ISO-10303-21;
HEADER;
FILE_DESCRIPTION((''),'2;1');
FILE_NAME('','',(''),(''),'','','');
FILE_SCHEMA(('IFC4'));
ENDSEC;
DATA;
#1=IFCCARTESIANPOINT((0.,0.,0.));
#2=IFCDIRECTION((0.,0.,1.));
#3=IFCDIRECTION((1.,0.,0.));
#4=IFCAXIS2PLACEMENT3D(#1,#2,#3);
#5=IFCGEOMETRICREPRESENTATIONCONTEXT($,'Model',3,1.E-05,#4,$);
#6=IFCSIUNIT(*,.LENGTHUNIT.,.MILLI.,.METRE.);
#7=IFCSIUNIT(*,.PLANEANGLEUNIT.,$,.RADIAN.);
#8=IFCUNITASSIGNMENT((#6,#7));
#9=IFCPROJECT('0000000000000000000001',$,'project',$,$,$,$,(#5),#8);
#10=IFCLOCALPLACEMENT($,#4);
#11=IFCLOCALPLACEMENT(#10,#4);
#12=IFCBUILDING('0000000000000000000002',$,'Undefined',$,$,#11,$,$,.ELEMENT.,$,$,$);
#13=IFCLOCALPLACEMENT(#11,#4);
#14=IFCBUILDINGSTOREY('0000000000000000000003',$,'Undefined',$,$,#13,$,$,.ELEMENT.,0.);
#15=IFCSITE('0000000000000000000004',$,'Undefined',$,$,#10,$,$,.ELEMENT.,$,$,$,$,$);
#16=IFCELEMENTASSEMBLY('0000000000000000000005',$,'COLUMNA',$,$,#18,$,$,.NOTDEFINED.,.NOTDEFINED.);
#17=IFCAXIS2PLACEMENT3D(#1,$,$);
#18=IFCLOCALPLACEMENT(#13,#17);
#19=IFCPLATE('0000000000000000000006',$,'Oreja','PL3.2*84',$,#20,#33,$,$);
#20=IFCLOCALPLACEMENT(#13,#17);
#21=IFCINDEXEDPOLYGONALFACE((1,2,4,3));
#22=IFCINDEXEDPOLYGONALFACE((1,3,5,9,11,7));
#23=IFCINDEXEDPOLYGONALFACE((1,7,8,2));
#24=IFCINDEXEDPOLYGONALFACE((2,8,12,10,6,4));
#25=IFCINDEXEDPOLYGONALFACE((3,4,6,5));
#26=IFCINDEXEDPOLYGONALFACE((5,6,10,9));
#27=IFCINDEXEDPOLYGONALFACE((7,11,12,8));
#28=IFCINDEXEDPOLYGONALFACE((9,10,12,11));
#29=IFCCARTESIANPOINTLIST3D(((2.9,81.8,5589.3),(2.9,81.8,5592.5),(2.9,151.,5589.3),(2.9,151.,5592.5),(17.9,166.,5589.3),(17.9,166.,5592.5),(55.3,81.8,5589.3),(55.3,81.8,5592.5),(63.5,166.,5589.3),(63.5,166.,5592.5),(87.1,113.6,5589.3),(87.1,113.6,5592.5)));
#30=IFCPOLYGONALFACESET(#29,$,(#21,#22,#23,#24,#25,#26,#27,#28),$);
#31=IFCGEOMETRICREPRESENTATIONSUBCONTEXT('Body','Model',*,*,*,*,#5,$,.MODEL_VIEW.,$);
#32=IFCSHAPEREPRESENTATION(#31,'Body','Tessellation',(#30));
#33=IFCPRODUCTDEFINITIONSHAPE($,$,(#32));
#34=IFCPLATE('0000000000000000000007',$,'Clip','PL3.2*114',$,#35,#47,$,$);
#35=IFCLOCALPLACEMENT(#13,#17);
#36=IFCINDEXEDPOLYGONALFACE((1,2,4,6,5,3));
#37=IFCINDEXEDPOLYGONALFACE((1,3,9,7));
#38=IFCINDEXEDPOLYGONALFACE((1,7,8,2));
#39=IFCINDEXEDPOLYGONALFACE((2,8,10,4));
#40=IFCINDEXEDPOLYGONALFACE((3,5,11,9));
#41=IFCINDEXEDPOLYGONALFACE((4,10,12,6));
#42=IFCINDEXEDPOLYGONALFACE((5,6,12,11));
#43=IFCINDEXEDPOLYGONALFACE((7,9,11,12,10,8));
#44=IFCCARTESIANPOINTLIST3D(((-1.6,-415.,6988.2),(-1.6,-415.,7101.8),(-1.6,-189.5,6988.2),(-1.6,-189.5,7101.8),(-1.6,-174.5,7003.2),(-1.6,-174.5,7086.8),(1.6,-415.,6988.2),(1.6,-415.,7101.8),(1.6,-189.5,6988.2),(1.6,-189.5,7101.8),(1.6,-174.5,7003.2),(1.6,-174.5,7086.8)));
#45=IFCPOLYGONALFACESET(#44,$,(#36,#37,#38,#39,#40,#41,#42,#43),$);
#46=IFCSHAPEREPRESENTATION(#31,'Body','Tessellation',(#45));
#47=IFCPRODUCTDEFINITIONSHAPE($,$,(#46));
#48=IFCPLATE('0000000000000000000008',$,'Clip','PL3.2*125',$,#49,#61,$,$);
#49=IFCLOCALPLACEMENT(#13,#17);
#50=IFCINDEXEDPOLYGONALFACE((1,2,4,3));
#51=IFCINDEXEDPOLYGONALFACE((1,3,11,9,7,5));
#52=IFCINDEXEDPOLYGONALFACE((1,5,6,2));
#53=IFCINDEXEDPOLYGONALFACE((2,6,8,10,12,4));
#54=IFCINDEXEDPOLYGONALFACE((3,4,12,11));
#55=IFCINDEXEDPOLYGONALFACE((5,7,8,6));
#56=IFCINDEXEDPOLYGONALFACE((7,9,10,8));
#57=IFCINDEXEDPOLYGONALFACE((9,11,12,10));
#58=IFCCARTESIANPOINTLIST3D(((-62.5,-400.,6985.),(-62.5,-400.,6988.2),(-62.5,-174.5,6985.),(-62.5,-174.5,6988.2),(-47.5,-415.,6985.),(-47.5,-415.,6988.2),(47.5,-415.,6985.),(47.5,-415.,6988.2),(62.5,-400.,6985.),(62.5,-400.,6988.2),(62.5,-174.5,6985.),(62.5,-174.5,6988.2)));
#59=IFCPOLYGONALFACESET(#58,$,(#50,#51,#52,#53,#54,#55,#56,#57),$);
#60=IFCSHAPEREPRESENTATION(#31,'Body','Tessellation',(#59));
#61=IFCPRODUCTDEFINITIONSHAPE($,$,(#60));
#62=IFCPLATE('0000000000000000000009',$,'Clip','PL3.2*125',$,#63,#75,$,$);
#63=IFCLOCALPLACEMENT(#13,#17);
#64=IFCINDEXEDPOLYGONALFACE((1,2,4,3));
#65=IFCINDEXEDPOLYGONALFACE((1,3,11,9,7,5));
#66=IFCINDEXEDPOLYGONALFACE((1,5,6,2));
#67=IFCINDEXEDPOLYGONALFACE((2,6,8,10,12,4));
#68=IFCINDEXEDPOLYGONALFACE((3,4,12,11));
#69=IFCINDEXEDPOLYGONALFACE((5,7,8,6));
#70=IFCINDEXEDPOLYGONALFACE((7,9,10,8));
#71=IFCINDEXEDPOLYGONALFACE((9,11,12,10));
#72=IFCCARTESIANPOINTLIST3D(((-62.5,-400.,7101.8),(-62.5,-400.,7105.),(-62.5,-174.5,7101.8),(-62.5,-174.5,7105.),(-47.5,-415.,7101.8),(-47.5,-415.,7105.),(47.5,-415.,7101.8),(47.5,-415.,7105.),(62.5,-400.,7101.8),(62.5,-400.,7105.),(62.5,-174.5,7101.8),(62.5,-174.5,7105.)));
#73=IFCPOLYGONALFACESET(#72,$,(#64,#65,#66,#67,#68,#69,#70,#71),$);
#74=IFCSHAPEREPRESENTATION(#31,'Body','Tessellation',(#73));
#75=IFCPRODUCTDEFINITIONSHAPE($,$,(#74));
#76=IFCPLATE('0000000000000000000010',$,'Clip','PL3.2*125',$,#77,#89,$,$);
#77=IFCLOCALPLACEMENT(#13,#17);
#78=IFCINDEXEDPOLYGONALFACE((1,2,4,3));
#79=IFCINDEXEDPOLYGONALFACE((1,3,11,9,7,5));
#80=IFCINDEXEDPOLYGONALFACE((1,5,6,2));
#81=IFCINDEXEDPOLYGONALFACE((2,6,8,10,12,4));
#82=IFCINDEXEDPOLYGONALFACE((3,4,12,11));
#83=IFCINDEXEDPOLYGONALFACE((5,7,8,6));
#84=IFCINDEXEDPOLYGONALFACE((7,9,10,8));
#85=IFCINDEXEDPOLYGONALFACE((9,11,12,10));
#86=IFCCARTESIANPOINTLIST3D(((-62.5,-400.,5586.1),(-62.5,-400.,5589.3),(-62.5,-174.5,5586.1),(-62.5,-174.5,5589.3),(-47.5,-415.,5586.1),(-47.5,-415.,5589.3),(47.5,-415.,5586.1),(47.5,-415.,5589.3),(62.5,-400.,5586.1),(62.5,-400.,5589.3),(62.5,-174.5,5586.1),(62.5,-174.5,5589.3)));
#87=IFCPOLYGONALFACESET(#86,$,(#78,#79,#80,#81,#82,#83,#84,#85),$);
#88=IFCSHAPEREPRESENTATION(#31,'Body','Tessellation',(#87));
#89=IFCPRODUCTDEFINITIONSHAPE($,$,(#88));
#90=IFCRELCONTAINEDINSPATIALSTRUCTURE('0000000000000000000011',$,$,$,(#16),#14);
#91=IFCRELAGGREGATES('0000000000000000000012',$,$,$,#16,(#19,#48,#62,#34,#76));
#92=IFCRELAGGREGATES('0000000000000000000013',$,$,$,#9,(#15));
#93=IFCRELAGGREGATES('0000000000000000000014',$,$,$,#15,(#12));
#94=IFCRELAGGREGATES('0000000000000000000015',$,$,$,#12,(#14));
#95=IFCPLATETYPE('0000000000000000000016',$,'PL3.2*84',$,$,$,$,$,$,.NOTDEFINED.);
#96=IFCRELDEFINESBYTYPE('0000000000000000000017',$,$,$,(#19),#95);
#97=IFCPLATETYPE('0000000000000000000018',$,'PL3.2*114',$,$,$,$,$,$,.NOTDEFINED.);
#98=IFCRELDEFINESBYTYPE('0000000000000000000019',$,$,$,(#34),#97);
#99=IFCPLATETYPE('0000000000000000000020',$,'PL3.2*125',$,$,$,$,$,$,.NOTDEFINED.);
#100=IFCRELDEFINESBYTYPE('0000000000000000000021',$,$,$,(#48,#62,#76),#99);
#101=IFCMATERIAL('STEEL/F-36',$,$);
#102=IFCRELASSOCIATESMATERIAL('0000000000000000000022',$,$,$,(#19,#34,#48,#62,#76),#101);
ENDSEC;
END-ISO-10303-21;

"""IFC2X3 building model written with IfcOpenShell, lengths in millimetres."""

from ifc_helpers import new_model, si_unit, frame, origin_with_axes, place, context, subcontext, project, spatial, polyline, outline, extrude, material, type_object, element, aggregate, save


model = new_model("IFC2X3")

# Units and contexts
model_context = context("Model", 3, precision=1e-05, world=origin_with_axes())
body_context = subcontext(model_context, "Body", "Model", "MODEL_VIEW")
ifc_project = project(units=[si_unit("LENGTHUNIT", "METRE", prefix="MILLI"), si_unit("PLANEANGLEUNIT", "RADIAN")], contexts=[model_context])

# Site, building, storey
site_placement = place(None, origin_with_axes())
site = spatial("IfcSite", under=ifc_project, at=site_placement, Name="Undefined", CompositionType="ELEMENT")
building_placement = place(site_placement, origin_with_axes())
building = spatial("IfcBuilding", under=site, at=building_placement, Name="Undefined", CompositionType="ELEMENT")
storey_placement = place(building_placement, origin_with_axes())
storey = spatial("IfcBuildingStorey", under=building, at=storey_placement, Name="Undefined", CompositionType="ELEMENT", Elevation=0.0)

# Element assembly, plates
assembly_1_placement = place(storey_placement, origin_with_axes())
assembly_1 = element("IfcElementAssembly", 1, at=assembly_1_placement, inside=storey, Name="COLUMNA", AssemblyPlace="NOTDEFINED", PredefinedType="NOTDEFINED")
ifc_material_1 = material(Name="STEEL/F-36")
plate_type_1 = type_object("IfcPlateType", Name="PL3.2*84", PredefinedType="NOTDEFINED")
plate_1_placement = place(assembly_1_placement, frame((2.9, 166.0, 5590.9), z_axis=(0.0, 0.000007, -1.0), x_axis=(1.0, 0.000008, 0.0)))
plate_1 = element("IfcPlate", 2, at=plate_1_placement, type_object=plate_type_1, material=ifc_material_1, Name="Oreja", Description="PL3.2*84", context=body_context, shape_type="SweptSolid", body=[
    extrude(outline(polyline([(0.0, 15.0), (15.0, 0.0), (60.6, 0.0), (84.2, 52.4), (52.4, 84.2), (0.0, 84.2), (0.0, 15.0)])), frame((0.0, 0.0, -1.6), z_axis=(0.0, 0.0, 1.0), x_axis=(1.0, 0.0, 0.0)), (0.0, 0.0, 1.0), 3.2),
])
plate_type_2 = type_object("IfcPlateType", Name="PL3.2*114", PredefinedType="NOTDEFINED")
plate_2_placement = place(assembly_1_placement, frame((0.0, -415.0, 6988.2), z_axis=(-1.0, 0.0, 0.0), x_axis=(0.0, 0.000148, 1.0)))
plate_2 = element("IfcPlate", 3, at=plate_2_placement, type_object=plate_type_2, material=ifc_material_1, Name="Clip", Description="PL3.2*114", context=body_context, shape_type="SweptSolid", body=[
    extrude(outline(polyline([(0.0, 0.0), (113.6, 0.0), (113.6, 225.5), (98.6, 240.5), (15.0, 240.5), (0.0, 225.5), (0.0, 0.0)])), frame((0.0, 0.0, -1.6), z_axis=(0.0, 0.0, 1.0), x_axis=(1.0, 0.0, 0.0)), (0.0, 0.0, 1.0), 3.2),
])
plate_type_3 = type_object("IfcPlateType", Name="PL3.2*125", PredefinedType="NOTDEFINED")
plate_3_placement = place(assembly_1_placement, frame((62.5, -174.5, 6986.6), z_axis=(0.0, 0.000103, 1.0), x_axis=(-1.0, 0.0, 0.0)))
plate_3 = element("IfcPlate", 4, at=plate_3_placement, type_object=plate_type_3, material=ifc_material_1, Name="Clip", Description="PL3.2*125", context=body_context, shape_type="SweptSolid", body=[
    extrude(outline(polyline([(0.0, 0.0), (125.0, 0.0), (125.0, 225.5), (110.0, 240.5), (15.0, 240.5), (0.0, 225.5), (0.0, 0.0)])), frame((0.0, 0.0, -1.6), z_axis=(0.0, 0.0, 1.0), x_axis=(1.0, 0.0, 0.0)), (0.0, 0.0, 1.0), 3.2),
])
plate_4_placement = place(assembly_1_placement, frame((62.5, -174.5, 7103.4), z_axis=(0.0, 0.000103, 1.0), x_axis=(-1.0, 0.0, 0.0)))
plate_4 = element("IfcPlate", 5, at=plate_4_placement, type_object=plate_type_3, material=ifc_material_1, Name="Clip", Description="PL3.2*125", context=body_context, shape_type="SweptSolid", body=[
    extrude(outline(polyline([(0.0, 0.0), (125.0, 0.0), (125.0, 225.5), (110.0, 240.5), (15.0, 240.5), (0.0, 225.5), (0.0, 0.0)])), frame((0.0, 0.0, -1.6), z_axis=(0.0, 0.0, 1.0), x_axis=(1.0, 0.0, 0.0)), (0.0, 0.0, 1.0), 3.2),
])
plate_5_placement = place(assembly_1_placement, frame((-62.5, -174.5, 5587.7), z_axis=(0.0, 0.000005, -1.0), x_axis=(1.0, 0.0, 0.0)))
plate_5 = element("IfcPlate", 6, at=plate_5_placement, type_object=plate_type_3, material=ifc_material_1, Name="Clip", Description="PL3.2*125", context=body_context, shape_type="SweptSolid", body=[
    extrude(outline(polyline([(0.0, 0.0), (125.0, 0.0), (125.0, 225.5), (110.0, 240.5), (15.0, 240.5), (0.0, 225.5), (0.0, 0.0)])), frame((0.0, 0.0, -1.6), z_axis=(0.0, 0.0, 1.0), x_axis=(1.0, 0.0, 0.0)), (0.0, 0.0, 1.0), 3.2),
])

aggregate(assembly_1, [plate_1, plate_3, plate_4, plate_2, plate_5])

save(model, "model.ifc")
